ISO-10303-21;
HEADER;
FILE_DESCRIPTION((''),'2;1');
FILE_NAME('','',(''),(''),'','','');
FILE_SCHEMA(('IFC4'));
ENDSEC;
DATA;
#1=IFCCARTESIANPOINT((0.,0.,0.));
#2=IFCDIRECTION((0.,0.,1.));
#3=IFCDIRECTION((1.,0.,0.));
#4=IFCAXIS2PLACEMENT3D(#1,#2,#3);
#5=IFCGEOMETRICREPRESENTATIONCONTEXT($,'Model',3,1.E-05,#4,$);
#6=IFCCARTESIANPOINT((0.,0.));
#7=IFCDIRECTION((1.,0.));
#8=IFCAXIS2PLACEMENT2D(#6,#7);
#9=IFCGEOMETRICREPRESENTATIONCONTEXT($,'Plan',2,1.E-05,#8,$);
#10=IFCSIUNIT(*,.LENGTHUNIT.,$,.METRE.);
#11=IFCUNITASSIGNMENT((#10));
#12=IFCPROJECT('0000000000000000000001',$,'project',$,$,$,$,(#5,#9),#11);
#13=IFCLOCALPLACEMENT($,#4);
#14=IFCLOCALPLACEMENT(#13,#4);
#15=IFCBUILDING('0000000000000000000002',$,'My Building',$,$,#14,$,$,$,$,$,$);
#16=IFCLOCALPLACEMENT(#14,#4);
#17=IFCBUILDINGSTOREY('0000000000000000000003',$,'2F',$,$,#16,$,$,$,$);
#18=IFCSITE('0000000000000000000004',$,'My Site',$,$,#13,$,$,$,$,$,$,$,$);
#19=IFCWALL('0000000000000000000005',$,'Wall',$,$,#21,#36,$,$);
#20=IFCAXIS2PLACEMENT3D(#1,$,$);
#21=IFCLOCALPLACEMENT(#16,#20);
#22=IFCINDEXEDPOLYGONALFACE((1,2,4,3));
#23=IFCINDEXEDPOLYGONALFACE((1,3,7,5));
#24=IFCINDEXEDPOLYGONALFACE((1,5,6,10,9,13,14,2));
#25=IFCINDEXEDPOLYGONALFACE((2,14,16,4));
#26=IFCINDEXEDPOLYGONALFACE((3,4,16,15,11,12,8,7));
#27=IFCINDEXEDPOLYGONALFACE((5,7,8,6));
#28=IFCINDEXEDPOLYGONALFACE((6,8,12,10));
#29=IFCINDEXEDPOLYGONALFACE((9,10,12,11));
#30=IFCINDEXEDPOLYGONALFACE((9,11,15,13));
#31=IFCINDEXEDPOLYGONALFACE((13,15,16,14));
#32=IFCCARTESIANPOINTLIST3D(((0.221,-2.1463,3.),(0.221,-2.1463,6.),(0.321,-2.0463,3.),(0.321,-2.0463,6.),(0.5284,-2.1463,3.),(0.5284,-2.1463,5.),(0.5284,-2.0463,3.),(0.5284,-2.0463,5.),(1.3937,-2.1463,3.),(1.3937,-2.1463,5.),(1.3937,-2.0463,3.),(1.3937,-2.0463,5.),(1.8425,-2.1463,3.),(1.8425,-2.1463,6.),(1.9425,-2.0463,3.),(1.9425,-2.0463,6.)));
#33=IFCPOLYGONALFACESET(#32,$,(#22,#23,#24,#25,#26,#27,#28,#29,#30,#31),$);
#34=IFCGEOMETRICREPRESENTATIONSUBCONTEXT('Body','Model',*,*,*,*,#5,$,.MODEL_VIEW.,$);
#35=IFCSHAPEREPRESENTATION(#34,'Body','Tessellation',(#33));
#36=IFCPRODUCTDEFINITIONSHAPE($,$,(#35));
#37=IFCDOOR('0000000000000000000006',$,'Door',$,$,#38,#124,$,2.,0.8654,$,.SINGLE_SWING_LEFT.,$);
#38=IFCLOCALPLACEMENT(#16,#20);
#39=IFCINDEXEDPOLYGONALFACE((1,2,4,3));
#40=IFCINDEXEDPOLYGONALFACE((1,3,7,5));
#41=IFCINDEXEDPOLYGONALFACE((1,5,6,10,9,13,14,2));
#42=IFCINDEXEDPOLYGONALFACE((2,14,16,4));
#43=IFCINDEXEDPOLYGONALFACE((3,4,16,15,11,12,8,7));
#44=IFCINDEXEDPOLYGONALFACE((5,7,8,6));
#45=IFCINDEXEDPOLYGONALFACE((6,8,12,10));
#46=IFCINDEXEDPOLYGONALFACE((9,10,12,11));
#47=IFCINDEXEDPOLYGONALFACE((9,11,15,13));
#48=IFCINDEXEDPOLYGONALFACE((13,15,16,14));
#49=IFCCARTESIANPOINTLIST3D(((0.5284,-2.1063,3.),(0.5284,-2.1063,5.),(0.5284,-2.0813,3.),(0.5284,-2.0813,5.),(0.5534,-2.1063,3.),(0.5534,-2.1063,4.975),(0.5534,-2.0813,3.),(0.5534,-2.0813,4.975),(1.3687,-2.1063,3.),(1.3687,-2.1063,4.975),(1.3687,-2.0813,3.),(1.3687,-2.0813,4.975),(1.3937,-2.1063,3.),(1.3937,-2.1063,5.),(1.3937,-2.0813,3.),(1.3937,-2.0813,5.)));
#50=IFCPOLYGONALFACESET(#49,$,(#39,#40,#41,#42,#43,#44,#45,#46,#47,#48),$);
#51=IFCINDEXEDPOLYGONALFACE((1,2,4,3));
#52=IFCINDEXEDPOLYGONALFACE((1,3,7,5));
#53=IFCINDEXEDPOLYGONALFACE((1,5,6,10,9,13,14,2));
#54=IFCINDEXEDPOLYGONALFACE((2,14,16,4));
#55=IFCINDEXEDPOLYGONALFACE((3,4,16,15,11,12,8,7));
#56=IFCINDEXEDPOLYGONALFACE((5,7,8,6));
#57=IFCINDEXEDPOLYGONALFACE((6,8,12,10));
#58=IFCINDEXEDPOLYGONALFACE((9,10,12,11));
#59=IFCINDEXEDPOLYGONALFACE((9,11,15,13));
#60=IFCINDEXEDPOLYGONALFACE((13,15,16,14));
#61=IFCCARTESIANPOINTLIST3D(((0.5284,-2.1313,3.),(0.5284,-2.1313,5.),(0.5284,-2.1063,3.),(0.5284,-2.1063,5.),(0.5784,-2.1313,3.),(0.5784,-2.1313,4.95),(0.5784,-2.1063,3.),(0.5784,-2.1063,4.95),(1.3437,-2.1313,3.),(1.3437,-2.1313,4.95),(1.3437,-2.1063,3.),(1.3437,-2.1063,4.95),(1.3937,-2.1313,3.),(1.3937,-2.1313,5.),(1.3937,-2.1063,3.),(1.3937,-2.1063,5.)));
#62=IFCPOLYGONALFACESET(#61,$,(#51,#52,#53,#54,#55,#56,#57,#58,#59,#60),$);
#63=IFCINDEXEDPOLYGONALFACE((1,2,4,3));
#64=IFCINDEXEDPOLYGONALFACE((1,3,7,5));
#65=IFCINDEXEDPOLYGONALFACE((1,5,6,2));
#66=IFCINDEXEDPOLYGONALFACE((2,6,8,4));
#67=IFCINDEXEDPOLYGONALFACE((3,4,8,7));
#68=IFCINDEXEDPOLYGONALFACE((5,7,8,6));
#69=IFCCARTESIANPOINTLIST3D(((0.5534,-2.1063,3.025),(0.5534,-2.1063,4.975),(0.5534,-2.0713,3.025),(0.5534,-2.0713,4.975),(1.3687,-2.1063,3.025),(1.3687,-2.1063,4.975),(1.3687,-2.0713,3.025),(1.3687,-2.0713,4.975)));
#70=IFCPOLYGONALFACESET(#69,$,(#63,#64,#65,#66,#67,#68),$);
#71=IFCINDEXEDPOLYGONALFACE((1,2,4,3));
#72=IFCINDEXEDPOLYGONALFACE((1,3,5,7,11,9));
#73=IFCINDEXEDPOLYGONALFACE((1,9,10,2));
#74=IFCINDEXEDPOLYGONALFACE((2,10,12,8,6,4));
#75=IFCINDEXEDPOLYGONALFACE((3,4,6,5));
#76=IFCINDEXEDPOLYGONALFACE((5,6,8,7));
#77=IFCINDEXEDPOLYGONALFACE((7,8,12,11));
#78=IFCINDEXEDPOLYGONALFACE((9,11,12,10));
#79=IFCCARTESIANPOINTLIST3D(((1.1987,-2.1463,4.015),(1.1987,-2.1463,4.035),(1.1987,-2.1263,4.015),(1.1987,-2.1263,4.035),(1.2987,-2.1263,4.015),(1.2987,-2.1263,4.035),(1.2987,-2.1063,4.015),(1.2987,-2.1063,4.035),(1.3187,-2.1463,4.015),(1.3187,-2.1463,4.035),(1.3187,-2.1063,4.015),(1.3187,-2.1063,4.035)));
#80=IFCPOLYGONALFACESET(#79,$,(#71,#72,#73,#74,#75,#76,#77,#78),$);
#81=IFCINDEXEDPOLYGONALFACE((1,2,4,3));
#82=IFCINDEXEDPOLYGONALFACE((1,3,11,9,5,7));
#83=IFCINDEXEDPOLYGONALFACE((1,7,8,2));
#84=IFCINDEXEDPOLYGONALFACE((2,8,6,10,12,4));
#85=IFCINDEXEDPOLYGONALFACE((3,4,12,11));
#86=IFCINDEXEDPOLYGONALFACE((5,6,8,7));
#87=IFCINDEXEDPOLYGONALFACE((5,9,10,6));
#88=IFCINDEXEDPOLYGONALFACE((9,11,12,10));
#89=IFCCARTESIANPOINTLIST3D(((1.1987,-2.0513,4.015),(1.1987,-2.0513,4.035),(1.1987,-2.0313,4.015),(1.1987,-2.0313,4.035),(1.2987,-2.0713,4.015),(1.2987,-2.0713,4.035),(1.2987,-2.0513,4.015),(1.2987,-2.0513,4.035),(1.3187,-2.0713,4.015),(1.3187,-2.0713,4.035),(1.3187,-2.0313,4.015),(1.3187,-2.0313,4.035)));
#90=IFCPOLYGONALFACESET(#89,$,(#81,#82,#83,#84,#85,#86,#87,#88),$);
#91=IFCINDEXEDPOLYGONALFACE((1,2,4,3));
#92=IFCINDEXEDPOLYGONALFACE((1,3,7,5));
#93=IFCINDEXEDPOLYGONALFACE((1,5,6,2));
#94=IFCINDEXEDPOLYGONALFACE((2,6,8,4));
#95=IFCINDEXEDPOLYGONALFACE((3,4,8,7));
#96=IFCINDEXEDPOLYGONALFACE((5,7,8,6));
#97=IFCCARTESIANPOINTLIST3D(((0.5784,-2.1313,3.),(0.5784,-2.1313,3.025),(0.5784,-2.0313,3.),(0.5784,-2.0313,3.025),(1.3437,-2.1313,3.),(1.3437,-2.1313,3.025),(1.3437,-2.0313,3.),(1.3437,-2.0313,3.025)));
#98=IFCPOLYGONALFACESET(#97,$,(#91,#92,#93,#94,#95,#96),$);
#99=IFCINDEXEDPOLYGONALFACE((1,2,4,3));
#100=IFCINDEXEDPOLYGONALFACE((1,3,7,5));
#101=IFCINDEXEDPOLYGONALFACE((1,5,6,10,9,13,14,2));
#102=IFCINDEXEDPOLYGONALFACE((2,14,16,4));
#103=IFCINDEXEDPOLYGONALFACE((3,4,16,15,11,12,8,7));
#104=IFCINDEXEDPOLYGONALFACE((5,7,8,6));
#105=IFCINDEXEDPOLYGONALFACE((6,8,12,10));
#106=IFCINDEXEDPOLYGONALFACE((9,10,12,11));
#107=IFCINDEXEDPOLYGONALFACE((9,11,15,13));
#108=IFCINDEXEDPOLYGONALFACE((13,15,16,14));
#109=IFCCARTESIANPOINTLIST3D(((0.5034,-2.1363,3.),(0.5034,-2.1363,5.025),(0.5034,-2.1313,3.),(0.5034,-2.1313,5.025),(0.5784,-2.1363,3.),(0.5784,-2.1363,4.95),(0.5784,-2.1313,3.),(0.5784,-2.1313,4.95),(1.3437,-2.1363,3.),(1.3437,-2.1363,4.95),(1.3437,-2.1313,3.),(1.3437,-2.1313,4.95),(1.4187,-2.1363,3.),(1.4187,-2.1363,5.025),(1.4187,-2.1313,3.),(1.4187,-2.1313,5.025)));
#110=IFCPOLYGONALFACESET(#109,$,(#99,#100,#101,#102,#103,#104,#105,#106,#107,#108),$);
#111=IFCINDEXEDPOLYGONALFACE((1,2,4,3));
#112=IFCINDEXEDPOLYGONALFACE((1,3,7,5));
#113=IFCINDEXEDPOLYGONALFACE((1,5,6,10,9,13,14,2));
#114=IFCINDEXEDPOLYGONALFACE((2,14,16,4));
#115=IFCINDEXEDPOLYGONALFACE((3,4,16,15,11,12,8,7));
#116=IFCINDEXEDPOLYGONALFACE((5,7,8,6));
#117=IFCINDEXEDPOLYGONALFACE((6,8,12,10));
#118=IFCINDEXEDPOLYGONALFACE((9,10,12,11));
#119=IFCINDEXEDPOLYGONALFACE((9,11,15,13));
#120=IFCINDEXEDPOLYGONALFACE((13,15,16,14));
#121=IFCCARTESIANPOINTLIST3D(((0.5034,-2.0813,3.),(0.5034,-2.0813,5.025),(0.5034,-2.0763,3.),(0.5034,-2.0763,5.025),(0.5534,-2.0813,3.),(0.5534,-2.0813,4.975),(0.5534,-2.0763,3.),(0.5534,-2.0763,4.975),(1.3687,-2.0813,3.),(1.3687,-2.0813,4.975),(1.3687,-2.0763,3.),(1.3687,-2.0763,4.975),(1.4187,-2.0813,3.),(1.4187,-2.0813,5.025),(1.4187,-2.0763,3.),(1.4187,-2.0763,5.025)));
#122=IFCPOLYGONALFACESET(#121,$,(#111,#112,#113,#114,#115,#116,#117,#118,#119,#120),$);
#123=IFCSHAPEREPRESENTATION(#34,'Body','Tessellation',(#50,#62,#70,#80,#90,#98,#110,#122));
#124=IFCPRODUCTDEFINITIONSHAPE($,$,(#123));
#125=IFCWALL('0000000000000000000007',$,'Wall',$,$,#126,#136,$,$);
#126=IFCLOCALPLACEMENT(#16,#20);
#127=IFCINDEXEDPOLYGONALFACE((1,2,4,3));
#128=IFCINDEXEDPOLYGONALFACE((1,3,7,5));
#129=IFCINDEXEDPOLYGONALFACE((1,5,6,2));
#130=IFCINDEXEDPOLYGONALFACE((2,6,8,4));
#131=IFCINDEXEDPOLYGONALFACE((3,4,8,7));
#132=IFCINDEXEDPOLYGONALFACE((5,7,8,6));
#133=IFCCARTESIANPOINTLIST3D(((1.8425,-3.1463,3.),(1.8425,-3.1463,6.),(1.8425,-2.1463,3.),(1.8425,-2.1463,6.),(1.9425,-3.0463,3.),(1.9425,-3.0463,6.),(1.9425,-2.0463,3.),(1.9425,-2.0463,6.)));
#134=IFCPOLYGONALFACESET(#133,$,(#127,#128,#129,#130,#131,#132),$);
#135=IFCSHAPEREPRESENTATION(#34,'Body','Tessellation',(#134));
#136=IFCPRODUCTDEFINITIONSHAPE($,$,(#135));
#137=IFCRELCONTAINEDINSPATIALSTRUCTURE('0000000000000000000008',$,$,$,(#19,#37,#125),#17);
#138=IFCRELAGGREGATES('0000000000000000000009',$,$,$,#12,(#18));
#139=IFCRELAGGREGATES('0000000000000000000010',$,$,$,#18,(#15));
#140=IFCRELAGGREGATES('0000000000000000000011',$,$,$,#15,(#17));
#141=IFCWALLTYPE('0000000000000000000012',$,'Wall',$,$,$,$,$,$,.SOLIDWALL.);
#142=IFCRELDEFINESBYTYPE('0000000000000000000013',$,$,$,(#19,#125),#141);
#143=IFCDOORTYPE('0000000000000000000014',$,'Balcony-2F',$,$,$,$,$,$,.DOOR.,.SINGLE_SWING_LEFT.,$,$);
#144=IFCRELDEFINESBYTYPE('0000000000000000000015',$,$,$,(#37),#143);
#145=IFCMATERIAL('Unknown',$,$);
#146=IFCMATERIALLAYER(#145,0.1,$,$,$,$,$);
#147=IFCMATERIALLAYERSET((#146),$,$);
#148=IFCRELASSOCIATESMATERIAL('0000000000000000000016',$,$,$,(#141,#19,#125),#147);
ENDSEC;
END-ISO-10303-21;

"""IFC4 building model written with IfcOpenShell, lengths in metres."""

from ifc_helpers import new_model, entity, si_unit, frame, origin_with_axes, origin_2d_with_axis, place, context, subcontext, project, spatial, line, indexed_curve, outline, extrude, shape, source, transform, mapped, material, layer, layer_set, layer_usage, type_object, type_shapes, element, fill, save


model = new_model("IFC4")

# Units and contexts
model_context = context("Model", 3, precision=1e-05, world=origin_with_axes())
plan_context = context("Plan", 2, precision=1e-05, world=origin_2d_with_axis())
body_context_1 = subcontext(model_context, "Body", "Model", "MODEL_VIEW")
body_context_2 = subcontext(plan_context, "Body", "Plan", "PLAN_VIEW")
ifc_project = project(units=[si_unit("LENGTHUNIT", "METRE")], contexts=[model_context, plan_context])

# Site, building, storey
site_placement = place(None, origin_with_axes())
site = spatial("IfcSite", under=ifc_project, at=site_placement, Name="My Site")
building_placement = place(site_placement, origin_with_axes())
building = spatial("IfcBuilding", under=site, at=building_placement, Name="My Building")
storey_placement = place(building_placement, origin_with_axes())
storey = spatial("IfcBuildingStorey", under=building, at=storey_placement, Name="2F")

# Shared definitions
ifc_material = material(Name="Unknown")

# Shared definitions
ifc_layer_1 = layer(ifc_material, 0.1)
ifc_layer_set_1 = layer_set([ifc_layer_1])
wall_type = type_object("IfcWallType", Name="Wall", PredefinedType="SOLIDWALL", material=ifc_layer_set_1)

# Wall, opening, door
ifc_layer_usage_1 = layer_usage(ifc_layer_set_1, "AXIS2", "POSITIVE", 0.0)
wall_1_placement = place(storey_placement, frame((0.221, -2.1463, 3.0), z_axis=(0.0, 0.0, 1.0), x_axis=(1.0, 0.0, 0.0)))
wall_1 = element("IfcWall", 1, at=wall_1_placement, inside=storey, type_object=wall_type, material=ifc_layer_usage_1, Name="Wall", context=body_context_1, shape_type="SweptSolid", body=[
    extrude(outline(indexed_curve([(0.0, 0.0), (0.1, 0.1), (1.7215, 0.1), (1.6215, 0.0)], segments=[line(1, 2, 3, 4, 1)])), origin_with_axes(), (0.0, 0.0, 1.0), 3.0),
])
shared_shape_1 = source(origin_with_axes(), body_context_1, "Body", "SweptSolid", [
    extrude(outline(indexed_curve([(0.0, 0.0), (0.8654, 0.0), (0.8654, 2.0), (0.0, 2.0)], segments=[line(1, 2, 3, 4, 1)])), frame((0.0, -0.6, 0.0), z_axis=(0.0, -1.0, 0.0), x_axis=(1.0, 0.0, 0.0)), (0.0, 0.0, -1.0), 1.2),
])
opening_1_placement = place(wall_1_placement, frame((0.3074, 0.015, 0.0), z_axis=(0.0, 0.0, 1.0), x_axis=(1.0, 0.0, 0.0)))
opening_1 = element("IfcOpeningElement", 2, at=opening_1_placement, cuts=wall_1, PredefinedType="OPENING", context=body_context_1, shape_type="MappedRepresentation", body=[
    mapped(shared_shape_1, transform((0.0, 0.0, 0.0), x_axis=(1.0, 0.0, 0.0), y_axis=(0.0, 1.0, 0.0), z_axis=(0.0, 0.0, 1.0), scale=1.0)),
])
door_type_1 = type_object("IfcDoorType", Name="Balcony-2F", OperationType="SINGLE_SWING_LEFT", PredefinedType="DOOR")
shared_shape_2 = source(origin_with_axes(), body_context_1, "Body", "SweptSolid", [
    extrude(outline(indexed_curve([(0.0, 0.0), (0.0, 2.0), (0.8654, 2.0), (0.8654, 0.0), (0.8404, 0.0), (0.8404, 1.975), (0.025, 1.975), (0.025, 0.0)], segments=[line(1, 2, 3, 4, 5, 6, 7, 8, 1)])), frame((0.0, 0.025, 0.0), z_axis=(0.0, -1.0, 0.0), x_axis=(1.0, 0.0, 0.0)), (0.0, 0.0, -1.0), 0.025),
    extrude(outline(indexed_curve([(0.0, 0.0), (0.0, 2.0), (0.8654, 2.0), (0.8654, 0.0), (0.8154, 0.0), (0.8154, 1.95), (0.05, 1.95), (0.05, 0.0)], segments=[line(1, 2, 3, 4, 5, 6, 7, 8, 1)])), frame((0.0, 0.0, 0.0), z_axis=(0.0, -1.0, 0.0), x_axis=(1.0, 0.0, 0.0)), (0.0, 0.0, -1.0), 0.025),
    extrude(outline(indexed_curve([(0.0, 0.0), (0.8154, 0.0), (0.8154, 0.035), (0.0, 0.035)], segments=[line(1, 2, 3, 4, 1)])), frame((0.025, 0.025, 0.025), z_axis=(0.0, 0.0, 1.0), x_axis=(1.0, 0.0, 0.0)), (0.0, 0.0, 1.0), 1.95),
    extrude(outline(indexed_curve([(0.0, 0.0), (0.0, -0.04), (-0.12, -0.04), (-0.12, -0.02), (-0.02, -0.02), (-0.02, 0.0)], segments=[line(1, 2, 3, 4, 5, 6, 1)])), frame((0.7904, 0.025, 1.015), z_axis=(0.0, 0.0, 1.0), x_axis=(1.0, 0.0, 0.0)), (0.0, 0.0, 1.0), 0.02),
    extrude(outline(indexed_curve([(0.0, 0.0), (0.0, 0.04), (-0.12, 0.04), (-0.12, 0.02), (-0.02, 0.02), (-0.02, 0.0)], segments=[line(1, 2, 3, 4, 5, 6, 1)])), frame((0.7904, 0.06, 1.015), z_axis=(0.0, 0.0, 1.0), x_axis=(1.0, 0.0, 0.0)), (0.0, 0.0, 1.0), 0.02),
    extrude(outline(indexed_curve([(0.0, 0.0), (0.7654, 0.0), (0.7654, 0.1), (0.0, 0.1)], segments=[line(1, 2, 3, 4, 1)])), frame((0.05, 0.0, 0.0), z_axis=(0.0, 0.0, 1.0), x_axis=(1.0, 0.0, 0.0)), (0.0, 0.0, 1.0), 0.025),
    extrude(outline(indexed_curve([(0.0, 0.0), (0.0, 2.025), (0.9154, 2.025), (0.9154, 0.0), (0.8404, 0.0), (0.8404, 1.95), (0.075, 1.95), (0.075, 0.0)], segments=[line(1, 2, 3, 4, 5, 6, 7, 8, 1)])), frame((-0.025, -0.005, 0.0), z_axis=(0.0, -1.0, 0.0), x_axis=(1.0, 0.0, 0.0)), (0.0, 0.0, -1.0), 0.005),
    extrude(outline(indexed_curve([(0.0, 0.0), (0.0, 2.025), (0.9154, 2.025), (0.9154, 0.0), (0.8654, 0.0), (0.8654, 1.975), (0.05, 1.975), (0.05, 0.0)], segments=[line(1, 2, 3, 4, 5, 6, 7, 8, 1)])), frame((-0.025, 0.05, 0.0), z_axis=(0.0, -1.0, 0.0), x_axis=(1.0, 0.0, 0.0)), (0.0, 0.0, -1.0), 0.005),
])
shared_shape_3 = source(origin_with_axes(), body_context_2, "Body", "Curve2D", [
    entity("IfcIndexedPolyCurve", entity("IfcCartesianPointList2D", [[0.0, 0.0], [0.0, 0.05], [0.025, 0.05], [0.025, 0.025], [0.05, 0.025], [0.05, 0.0]]), [entity("IfcLineIndex", [1, 2, 3, 4, 5, 6, 1])]),
    entity("IfcIndexedPolyCurve", entity("IfcCartesianPointList2D", [[0.8654, 0.0], [0.8654, 0.05], [0.8404, 0.05], [0.8404, 0.025], [0.8154, 0.025], [0.8154, 0.0]]), [entity("IfcLineIndex", [1, 2, 3, 4, 5, 6, 1])]),
    entity("IfcTrimmedCurve", entity("IfcEllipse", entity("IfcAxis2Placement2D", entity("IfcCartesianPoint", [0.06, 0.05]), entity("IfcDirection", [1.0, 0.0])), 0.7804, 0.8154), [entity("IfcCartesianPoint", [0.8404, 0.05])], [entity("IfcCartesianPoint", [0.06, 0.8654])], True, "CARTESIAN"),
    entity("IfcIndexedPolyCurve", entity("IfcCartesianPointList2D", [[0.025, 0.05], [0.06, 0.05], [0.06, 0.8654], [0.025, 0.8654]]), [entity("IfcLineIndex", [1, 2, 3, 4, 1])]),
])
type_shapes(door_type_1, [shared_shape_2, shared_shape_3])
door_1_placement = place(opening_1_placement, frame((0.0, 0.0, 0.0), z_axis=(0.0, 0.0, 1.0), x_axis=(1.0, 0.0, 0.0)))
door_1 = element("IfcDoor", 3, at=door_1_placement, inside=storey, type_object=door_type_1, Name="Door", OperationType="SINGLE_SWING_LEFT", OverallHeight=2.0, OverallWidth=0.8654, shapes=[
    shape(body_context_1, "Body", "MappedRepresentation", [mapped(shared_shape_2, transform((0.0, 0.0, 0.0), x_axis=(1.0, 0.0, 0.0), y_axis=(0.0, 1.0, 0.0), z_axis=(0.0, 0.0, 1.0), scale=1.0))]),
    shape(body_context_2, "Body", "MappedRepresentation", [mapped(shared_shape_3, transform((0.0, 0.0, 0.0), x_axis=(1.0, 0.0, 0.0), y_axis=(0.0, 1.0, 0.0), z_axis=(0.0, 0.0, 1.0), scale=1.0))]),
])
fill(opening_1, door_1)

# Wall
ifc_layer_usage_2 = layer_usage(ifc_layer_set_1, "AXIS2", "POSITIVE", 0.0)
wall_2_placement = place(storey_placement, frame((1.8425, -2.1463, 3.0), z_axis=(0.0, 0.0, 1.0), x_axis=(0.0, -1.0, 0.0)))
element("IfcWall", 4, at=wall_2_placement, inside=storey, type_object=wall_type, material=ifc_layer_usage_2, Name="Wall", context=body_context_1, shape_type="SweptSolid", body=[
    extrude(outline(indexed_curve([(0.0, 0.0), (-0.1, 0.1), (0.9, 0.1), (1.0, 0.0)], segments=[line(1, 2, 3, 4, 1)])), origin_with_axes(), (0.0, 0.0, 1.0), 3.0),
])

save(model, "model.ifc")
